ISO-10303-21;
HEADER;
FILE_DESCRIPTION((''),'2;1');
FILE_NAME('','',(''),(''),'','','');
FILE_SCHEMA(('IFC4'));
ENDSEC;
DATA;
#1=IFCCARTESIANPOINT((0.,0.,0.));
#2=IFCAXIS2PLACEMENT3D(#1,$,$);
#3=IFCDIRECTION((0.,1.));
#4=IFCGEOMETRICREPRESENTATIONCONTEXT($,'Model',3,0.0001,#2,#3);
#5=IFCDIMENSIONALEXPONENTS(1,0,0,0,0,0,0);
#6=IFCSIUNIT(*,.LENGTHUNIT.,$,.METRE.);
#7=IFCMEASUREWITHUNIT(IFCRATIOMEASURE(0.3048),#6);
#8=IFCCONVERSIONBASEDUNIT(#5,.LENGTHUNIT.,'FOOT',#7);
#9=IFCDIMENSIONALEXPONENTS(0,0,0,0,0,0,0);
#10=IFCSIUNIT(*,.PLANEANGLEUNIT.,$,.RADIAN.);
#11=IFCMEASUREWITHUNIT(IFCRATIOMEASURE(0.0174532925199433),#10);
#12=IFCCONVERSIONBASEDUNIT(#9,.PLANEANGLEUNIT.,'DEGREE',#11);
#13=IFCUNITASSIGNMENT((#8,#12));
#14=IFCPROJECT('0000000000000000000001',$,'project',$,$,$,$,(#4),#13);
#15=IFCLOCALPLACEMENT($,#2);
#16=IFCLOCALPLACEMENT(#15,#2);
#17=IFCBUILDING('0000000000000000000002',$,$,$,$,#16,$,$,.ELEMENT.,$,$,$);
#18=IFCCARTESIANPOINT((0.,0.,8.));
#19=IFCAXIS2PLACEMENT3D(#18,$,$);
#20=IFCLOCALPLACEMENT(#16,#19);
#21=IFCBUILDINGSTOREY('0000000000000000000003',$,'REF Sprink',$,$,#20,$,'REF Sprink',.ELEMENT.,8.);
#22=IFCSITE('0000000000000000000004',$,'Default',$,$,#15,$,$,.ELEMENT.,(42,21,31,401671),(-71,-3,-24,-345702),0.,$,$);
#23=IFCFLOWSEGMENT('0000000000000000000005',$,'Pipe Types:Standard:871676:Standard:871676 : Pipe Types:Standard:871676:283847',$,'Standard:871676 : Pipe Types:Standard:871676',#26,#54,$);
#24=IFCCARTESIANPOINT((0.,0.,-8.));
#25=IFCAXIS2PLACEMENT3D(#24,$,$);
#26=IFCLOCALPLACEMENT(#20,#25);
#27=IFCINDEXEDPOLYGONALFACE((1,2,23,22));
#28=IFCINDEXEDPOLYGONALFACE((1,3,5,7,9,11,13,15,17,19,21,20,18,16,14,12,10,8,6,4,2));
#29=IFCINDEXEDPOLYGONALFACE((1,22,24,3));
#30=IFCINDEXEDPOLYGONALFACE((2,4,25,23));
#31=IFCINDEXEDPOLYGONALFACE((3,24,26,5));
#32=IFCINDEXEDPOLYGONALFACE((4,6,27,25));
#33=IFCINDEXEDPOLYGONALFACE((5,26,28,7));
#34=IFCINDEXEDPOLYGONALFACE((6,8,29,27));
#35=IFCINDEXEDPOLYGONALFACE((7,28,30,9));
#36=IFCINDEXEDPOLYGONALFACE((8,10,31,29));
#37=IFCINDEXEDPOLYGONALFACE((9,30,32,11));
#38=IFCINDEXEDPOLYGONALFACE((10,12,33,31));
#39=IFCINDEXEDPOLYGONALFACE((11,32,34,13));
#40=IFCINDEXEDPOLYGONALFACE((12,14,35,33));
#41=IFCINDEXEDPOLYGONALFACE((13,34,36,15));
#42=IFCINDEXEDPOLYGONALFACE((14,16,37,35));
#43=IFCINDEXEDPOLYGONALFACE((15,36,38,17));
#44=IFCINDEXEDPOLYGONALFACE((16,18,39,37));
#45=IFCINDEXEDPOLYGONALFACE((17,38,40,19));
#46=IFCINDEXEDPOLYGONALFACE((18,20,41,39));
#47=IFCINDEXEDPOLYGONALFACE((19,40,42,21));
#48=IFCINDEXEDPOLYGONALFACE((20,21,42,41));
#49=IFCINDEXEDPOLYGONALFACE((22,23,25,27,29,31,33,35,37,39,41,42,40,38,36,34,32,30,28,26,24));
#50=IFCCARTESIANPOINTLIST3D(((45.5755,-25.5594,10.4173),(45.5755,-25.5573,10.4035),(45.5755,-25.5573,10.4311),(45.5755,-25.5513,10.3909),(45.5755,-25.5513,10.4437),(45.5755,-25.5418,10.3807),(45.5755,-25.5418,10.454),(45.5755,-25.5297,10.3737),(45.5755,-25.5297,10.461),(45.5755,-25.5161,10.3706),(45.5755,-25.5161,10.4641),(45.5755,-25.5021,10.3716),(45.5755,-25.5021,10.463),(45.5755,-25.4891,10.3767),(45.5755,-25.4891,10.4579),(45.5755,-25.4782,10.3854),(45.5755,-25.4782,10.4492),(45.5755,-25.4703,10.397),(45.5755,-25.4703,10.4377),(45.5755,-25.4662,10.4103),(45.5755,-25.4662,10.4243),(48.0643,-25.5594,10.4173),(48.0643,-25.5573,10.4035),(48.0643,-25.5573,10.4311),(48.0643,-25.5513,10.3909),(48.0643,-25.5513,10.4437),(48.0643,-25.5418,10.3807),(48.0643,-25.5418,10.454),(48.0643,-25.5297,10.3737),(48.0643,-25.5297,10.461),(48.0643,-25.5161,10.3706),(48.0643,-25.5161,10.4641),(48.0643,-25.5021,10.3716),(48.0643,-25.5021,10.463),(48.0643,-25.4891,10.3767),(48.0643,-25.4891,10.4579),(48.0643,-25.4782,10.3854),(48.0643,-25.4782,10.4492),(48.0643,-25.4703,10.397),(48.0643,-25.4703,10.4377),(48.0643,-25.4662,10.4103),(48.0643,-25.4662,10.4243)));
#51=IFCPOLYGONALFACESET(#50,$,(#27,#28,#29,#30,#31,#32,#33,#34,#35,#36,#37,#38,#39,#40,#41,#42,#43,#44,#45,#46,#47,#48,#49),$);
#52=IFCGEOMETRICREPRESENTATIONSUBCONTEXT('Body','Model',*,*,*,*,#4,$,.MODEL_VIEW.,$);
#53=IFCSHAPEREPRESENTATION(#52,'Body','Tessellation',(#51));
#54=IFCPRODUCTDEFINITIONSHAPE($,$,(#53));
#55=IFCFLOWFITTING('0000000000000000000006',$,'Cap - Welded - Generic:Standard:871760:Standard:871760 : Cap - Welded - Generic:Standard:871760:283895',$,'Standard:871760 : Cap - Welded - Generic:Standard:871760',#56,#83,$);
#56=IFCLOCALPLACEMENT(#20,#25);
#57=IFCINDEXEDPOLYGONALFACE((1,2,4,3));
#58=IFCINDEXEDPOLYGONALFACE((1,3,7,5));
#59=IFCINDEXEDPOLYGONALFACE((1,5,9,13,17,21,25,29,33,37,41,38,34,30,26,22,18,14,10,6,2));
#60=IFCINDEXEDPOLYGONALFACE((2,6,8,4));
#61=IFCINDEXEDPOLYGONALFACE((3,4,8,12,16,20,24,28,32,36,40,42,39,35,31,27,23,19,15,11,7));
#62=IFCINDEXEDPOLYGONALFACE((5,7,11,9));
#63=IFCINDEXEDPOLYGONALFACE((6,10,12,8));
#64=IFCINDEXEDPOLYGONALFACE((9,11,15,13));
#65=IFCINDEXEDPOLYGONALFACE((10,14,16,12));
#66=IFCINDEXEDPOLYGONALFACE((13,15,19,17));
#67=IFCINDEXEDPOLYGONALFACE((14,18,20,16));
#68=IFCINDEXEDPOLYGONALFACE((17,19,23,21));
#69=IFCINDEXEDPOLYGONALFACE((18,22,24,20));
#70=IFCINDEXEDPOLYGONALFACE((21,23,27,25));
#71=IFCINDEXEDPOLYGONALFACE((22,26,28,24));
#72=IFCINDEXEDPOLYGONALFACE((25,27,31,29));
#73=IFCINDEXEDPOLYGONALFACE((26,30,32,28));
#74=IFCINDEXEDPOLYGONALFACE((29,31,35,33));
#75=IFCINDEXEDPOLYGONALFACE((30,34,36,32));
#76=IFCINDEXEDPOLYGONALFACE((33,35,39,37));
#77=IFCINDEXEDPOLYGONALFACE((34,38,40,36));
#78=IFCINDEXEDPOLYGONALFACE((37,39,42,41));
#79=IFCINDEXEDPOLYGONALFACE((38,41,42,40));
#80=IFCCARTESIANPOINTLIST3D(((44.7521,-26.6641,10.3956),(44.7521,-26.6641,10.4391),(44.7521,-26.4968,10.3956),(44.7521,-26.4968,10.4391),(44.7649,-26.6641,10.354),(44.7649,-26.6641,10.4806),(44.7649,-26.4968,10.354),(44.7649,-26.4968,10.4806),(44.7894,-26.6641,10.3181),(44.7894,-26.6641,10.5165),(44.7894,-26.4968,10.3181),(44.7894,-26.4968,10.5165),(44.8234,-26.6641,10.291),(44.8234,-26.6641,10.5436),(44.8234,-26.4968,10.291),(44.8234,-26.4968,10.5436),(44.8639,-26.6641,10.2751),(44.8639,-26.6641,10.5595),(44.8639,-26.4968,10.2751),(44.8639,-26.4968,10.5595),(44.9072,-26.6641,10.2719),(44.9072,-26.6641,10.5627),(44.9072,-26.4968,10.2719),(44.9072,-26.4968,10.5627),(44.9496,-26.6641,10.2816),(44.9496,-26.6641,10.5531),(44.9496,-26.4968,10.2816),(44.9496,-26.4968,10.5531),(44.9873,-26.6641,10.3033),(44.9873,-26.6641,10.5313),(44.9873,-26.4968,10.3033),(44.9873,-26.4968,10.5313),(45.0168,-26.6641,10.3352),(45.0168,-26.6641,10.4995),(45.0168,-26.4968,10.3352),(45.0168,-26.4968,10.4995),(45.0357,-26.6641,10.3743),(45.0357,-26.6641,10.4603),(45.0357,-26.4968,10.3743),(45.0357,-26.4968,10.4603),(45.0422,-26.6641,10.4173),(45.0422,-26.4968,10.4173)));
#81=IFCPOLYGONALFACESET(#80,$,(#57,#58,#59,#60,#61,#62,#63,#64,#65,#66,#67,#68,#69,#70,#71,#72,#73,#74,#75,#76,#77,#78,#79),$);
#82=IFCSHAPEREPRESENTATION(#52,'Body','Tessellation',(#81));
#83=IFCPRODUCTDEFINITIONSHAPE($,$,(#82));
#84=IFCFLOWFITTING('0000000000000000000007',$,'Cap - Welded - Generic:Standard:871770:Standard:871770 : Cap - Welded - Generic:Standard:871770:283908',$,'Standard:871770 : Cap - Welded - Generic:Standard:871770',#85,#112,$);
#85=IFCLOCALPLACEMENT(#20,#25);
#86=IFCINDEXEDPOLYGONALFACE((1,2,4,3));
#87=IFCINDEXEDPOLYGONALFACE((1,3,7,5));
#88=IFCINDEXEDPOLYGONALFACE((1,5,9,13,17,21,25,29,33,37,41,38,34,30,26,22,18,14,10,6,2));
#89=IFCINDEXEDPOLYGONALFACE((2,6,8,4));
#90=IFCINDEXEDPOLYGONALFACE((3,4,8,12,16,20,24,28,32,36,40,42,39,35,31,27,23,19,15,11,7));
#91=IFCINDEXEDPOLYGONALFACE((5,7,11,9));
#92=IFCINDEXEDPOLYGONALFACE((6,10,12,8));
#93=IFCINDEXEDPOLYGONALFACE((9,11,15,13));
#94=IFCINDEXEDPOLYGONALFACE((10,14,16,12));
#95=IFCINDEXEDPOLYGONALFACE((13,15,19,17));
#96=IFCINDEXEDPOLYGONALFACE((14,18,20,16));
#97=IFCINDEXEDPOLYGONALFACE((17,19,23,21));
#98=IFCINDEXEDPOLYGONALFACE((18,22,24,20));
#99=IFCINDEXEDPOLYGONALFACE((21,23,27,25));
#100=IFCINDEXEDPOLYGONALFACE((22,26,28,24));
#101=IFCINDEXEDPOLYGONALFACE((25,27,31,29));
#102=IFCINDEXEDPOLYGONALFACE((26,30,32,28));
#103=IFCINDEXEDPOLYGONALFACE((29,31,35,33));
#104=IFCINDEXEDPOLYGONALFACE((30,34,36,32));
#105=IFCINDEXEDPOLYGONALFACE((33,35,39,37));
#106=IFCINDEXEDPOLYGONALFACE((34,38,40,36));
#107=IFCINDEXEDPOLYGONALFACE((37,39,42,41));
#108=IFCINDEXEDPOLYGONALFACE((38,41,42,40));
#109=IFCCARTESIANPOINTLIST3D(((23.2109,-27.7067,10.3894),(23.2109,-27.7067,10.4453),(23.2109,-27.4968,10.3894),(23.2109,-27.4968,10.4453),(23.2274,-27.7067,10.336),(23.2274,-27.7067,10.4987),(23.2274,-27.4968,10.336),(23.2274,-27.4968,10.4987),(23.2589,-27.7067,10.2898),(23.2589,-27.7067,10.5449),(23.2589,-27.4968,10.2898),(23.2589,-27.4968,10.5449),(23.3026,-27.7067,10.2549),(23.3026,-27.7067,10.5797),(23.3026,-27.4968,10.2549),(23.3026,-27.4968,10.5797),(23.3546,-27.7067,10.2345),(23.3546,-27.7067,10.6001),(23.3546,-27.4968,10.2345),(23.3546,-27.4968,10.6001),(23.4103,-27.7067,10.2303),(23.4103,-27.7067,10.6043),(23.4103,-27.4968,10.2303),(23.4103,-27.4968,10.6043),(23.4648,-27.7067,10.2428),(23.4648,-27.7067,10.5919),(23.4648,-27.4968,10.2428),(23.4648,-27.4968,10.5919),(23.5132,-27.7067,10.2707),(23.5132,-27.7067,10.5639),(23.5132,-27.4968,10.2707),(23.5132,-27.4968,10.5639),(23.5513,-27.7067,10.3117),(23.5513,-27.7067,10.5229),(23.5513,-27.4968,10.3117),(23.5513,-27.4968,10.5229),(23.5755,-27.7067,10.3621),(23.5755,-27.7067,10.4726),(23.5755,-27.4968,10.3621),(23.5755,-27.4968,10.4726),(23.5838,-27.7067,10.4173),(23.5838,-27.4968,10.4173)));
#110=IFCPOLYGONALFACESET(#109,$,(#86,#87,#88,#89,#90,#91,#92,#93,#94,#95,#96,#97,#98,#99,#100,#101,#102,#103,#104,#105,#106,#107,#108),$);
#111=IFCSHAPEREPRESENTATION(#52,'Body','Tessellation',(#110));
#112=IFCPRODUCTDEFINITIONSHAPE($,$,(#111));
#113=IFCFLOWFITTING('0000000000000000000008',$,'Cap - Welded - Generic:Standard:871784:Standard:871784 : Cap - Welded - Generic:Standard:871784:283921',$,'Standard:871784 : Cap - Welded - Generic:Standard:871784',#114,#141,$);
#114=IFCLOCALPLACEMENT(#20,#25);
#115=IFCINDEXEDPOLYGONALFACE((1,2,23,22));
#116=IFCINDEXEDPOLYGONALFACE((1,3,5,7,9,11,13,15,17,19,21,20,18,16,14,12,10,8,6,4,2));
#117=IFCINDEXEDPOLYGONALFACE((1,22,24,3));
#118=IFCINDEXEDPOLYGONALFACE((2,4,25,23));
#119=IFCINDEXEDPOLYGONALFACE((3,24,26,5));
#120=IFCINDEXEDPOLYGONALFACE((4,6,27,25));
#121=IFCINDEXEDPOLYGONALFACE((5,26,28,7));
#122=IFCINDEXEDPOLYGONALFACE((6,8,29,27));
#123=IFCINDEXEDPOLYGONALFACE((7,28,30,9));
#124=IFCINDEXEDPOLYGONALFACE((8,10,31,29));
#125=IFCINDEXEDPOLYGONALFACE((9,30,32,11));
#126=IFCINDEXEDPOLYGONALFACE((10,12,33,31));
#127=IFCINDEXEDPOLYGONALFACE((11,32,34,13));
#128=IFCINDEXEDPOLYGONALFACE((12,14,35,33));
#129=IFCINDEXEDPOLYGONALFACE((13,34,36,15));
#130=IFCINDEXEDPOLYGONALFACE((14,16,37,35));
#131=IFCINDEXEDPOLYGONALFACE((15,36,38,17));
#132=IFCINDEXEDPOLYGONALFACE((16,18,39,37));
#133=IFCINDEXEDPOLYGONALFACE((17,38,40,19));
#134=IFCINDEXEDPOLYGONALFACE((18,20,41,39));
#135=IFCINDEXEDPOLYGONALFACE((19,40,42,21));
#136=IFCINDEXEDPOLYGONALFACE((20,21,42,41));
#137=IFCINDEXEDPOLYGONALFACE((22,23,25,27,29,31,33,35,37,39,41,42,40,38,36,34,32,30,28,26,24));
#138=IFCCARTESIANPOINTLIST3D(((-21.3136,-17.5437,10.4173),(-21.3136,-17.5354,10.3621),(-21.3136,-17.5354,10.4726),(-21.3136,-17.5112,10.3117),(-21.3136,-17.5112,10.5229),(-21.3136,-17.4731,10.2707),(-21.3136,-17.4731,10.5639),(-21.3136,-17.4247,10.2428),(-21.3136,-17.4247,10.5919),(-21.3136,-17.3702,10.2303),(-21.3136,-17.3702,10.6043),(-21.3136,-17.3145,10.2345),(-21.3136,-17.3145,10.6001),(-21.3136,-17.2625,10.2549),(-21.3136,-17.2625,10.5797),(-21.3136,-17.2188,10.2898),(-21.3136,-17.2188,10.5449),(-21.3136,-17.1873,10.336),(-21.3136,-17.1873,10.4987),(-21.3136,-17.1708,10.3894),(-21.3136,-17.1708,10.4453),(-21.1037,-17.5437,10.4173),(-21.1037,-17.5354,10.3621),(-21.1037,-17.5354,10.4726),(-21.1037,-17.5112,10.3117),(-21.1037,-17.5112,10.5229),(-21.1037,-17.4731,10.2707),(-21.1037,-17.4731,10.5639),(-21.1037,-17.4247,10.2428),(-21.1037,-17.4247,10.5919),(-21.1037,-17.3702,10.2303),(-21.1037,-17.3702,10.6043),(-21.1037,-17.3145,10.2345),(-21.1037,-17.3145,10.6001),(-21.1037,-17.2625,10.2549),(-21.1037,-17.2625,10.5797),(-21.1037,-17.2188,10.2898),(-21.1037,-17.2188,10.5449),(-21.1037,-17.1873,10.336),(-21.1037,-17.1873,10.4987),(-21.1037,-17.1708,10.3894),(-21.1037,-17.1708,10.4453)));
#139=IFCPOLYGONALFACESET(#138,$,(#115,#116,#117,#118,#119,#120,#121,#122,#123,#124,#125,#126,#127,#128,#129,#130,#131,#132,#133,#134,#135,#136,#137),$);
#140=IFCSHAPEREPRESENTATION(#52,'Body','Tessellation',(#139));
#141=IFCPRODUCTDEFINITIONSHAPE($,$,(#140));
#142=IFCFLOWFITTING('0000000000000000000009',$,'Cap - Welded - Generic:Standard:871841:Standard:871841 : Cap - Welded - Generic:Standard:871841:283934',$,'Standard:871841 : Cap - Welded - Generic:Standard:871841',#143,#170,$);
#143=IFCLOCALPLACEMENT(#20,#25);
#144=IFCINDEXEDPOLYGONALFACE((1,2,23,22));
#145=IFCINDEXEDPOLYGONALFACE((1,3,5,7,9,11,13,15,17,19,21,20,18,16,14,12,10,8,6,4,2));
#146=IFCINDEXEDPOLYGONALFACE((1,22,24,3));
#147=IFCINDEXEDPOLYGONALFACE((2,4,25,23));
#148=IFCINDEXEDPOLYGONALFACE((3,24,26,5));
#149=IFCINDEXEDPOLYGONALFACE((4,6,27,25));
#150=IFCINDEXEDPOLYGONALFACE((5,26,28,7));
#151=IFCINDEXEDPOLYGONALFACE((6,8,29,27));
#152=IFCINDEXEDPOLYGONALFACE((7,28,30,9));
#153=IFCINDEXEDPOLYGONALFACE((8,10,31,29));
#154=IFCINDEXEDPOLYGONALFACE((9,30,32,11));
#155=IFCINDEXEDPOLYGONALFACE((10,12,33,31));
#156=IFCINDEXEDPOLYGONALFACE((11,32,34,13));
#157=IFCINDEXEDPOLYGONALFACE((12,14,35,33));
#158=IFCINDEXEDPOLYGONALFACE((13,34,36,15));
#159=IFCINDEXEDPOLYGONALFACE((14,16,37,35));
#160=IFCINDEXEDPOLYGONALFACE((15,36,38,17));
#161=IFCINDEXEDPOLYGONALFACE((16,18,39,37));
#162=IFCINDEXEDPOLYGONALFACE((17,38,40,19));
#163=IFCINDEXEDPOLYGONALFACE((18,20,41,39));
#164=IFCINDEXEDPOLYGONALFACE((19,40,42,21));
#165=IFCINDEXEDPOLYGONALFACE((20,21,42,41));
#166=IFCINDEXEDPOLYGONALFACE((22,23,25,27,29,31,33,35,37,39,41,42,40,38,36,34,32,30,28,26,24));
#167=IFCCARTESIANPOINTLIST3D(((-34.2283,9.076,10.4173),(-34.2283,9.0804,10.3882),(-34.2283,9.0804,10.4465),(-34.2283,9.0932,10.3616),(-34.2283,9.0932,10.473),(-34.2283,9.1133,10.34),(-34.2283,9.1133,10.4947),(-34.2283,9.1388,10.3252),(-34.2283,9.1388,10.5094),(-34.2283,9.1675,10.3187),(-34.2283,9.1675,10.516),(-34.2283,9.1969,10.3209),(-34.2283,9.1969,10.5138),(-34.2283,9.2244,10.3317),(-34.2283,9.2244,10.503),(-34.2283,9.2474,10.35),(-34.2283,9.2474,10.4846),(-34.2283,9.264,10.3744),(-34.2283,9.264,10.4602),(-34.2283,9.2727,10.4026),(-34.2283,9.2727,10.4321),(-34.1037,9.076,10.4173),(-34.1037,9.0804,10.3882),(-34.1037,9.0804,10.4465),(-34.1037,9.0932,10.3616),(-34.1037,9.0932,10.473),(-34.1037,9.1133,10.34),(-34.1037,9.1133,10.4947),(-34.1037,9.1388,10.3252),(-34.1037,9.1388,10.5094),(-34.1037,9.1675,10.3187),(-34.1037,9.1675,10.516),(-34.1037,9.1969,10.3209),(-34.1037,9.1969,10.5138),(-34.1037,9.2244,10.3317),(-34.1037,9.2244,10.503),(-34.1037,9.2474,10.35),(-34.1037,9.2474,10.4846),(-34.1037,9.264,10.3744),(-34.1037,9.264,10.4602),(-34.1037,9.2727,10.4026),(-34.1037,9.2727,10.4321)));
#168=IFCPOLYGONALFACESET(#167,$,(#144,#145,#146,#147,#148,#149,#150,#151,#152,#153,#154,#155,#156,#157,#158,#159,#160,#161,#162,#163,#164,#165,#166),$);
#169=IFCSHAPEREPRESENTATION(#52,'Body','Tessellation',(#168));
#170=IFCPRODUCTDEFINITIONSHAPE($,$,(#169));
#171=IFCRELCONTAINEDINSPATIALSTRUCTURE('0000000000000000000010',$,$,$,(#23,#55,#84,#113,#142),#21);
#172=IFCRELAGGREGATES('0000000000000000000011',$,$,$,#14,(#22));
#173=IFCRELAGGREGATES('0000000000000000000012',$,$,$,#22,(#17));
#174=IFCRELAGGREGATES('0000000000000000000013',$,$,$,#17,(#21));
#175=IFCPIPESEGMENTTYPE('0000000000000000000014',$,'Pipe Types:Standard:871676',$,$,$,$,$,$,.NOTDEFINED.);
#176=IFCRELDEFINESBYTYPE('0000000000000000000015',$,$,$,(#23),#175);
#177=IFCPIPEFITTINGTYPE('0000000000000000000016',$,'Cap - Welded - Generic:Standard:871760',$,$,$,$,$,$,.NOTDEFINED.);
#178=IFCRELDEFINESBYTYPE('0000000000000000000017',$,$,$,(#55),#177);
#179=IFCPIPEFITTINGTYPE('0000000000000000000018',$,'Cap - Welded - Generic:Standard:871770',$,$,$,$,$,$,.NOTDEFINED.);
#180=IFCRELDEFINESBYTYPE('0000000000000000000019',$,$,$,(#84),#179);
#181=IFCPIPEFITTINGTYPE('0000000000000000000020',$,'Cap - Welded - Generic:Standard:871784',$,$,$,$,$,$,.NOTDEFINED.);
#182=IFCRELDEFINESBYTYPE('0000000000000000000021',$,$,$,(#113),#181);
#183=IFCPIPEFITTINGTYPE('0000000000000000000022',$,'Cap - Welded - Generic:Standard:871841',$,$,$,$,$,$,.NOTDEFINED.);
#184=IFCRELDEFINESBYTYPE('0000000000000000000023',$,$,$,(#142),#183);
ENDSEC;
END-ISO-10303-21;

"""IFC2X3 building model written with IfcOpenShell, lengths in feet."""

from ifc_helpers import new_model, entity, si_unit, converted_unit, direction, frame, frame_2d, origin, origin_2d_with_axis, place, context, subcontext, project, spatial, circle, extrude, source, transform, mapped, type_object, type_shapes, element, save


model = new_model("IFC2X3")

# Units and contexts
model_context = context("Model", 3, precision=0.0001, world=origin(), true_north=direction((0.0, 1.0)))
body_context = subcontext(model_context, "Body", "Model", "MODEL_VIEW")
ifc_project = project(units=[converted_unit("LENGTHUNIT", "FOOT", entity("IfcRatioMeasure", 0.3048), si_unit("LENGTHUNIT", "METRE"), dimensions=[1, 0, 0, 0, 0, 0, 0]), converted_unit("PLANEANGLEUNIT", "DEGREE", entity("IfcRatioMeasure", 0.0174532925199433), si_unit("PLANEANGLEUNIT", "RADIAN"), dimensions=[0, 0, 0, 0, 0, 0, 0])], contexts=[model_context])

# Site, building, storey
site_placement = place(None, origin())
site = spatial("IfcSite", under=ifc_project, at=site_placement, Name="Default", CompositionType="ELEMENT", RefLatitude=(42, 21, 31, 401671), RefLongitude=(-71, -3, -24, -345702), RefElevation=0.0)
building_placement = place(site_placement, origin())
building = spatial("IfcBuilding", under=site, at=building_placement, CompositionType="ELEMENT")
storey_placement = place(building_placement, frame((0.0, 0.0, 8.0)))
storey = spatial("IfcBuildingStorey", under=building, at=storey_placement, Name="REF Sprink", LongName="REF Sprink", CompositionType="ELEMENT", Elevation=8.0)

# Flow segment
pipe_segment_type_1 = type_object("IfcPipeSegmentType", Name="Pipe Types:Standard:871676", PredefinedType="NOTDEFINED")
shared_shape_1 = source(origin(), body_context, "Body", "SweptSolid", [
    extrude(circle(Radius=0.0469, at=origin_2d_with_axis()), frame((45.5755, -25.5125, 10.4173), z_axis=(1.0, 0.0, 0.0), x_axis=(0.0, -1.0, 0.0)), (0.0, 0.0, 1.0), 2.4888),
])
type_shapes(pipe_segment_type_1, [shared_shape_1])
flow_segment_1_placement = place(storey_placement, frame((0.0, 0.0, -8.0)))
element("IfcFlowSegment", 1, at=flow_segment_1_placement, inside=storey, type_object=pipe_segment_type_1, Name="Pipe Types:Standard:871676:Standard:871676 : Pipe Types:Standard:871676:283847", ObjectType="Standard:871676 : Pipe Types:Standard:871676", context=body_context, shape_type="MappedRepresentation", body=[
    mapped(shared_shape_1, transform((0.0, 0.0, 0.0), scale=1.0)),
])

# Flow fittings
pipe_fitting_type_1 = type_object("IfcPipeFittingType", Name="Cap - Welded - Generic:Standard:871760", PredefinedType="NOTDEFINED")
shared_shape_2 = source(origin(), body_context, "Body", "SweptSolid", [
    extrude(circle(Radius=0.1458, at=frame_2d((0.0, 0.0), x_axis=(1.0, 0.0))), frame((44.8963, -26.6641, 10.4173), z_axis=(0.0, 1.0, 0.0), x_axis=(1.0, 0.0, 0.0)), (0.0, 0.0, 1.0), 0.1673),
])
type_shapes(pipe_fitting_type_1, [shared_shape_2])
flow_fitting_1_placement = place(storey_placement, frame((0.0, 0.0, -8.0)))
element("IfcFlowFitting", 2, at=flow_fitting_1_placement, inside=storey, type_object=pipe_fitting_type_1, Name="Cap - Welded - Generic:Standard:871760:Standard:871760 : Cap - Welded - Generic:Standard:871760:283895", ObjectType="Standard:871760 : Cap - Welded - Generic:Standard:871760", context=body_context, shape_type="MappedRepresentation", body=[
    mapped(shared_shape_2, transform((0.0, 0.0, 0.0), scale=1.0)),
])
pipe_fitting_type_2 = type_object("IfcPipeFittingType", Name="Cap - Welded - Generic:Standard:871770", PredefinedType="NOTDEFINED")
shared_shape_3 = source(origin(), body_context, "Body", "SweptSolid", [
    extrude(circle(Radius=0.1875, at=frame_2d((0.0, 0.0), x_axis=(1.0, 0.0))), frame((23.3963, -27.7067, 10.4173), z_axis=(0.0, 1.0, 0.0), x_axis=(1.0, 0.0, 0.0)), (0.0, 0.0, 1.0), 0.21),
])
type_shapes(pipe_fitting_type_2, [shared_shape_3])
flow_fitting_2_placement = place(storey_placement, frame((0.0, 0.0, -8.0)))
element("IfcFlowFitting", 3, at=flow_fitting_2_placement, inside=storey, type_object=pipe_fitting_type_2, Name="Cap - Welded - Generic:Standard:871770:Standard:871770 : Cap - Welded - Generic:Standard:871770:283908", ObjectType="Standard:871770 : Cap - Welded - Generic:Standard:871770", context=body_context, shape_type="MappedRepresentation", body=[
    mapped(shared_shape_3, transform((0.0, 0.0, 0.0), scale=1.0)),
])
pipe_fitting_type_3 = type_object("IfcPipeFittingType", Name="Cap - Welded - Generic:Standard:871784", PredefinedType="NOTDEFINED")
shared_shape_4 = source(origin(), body_context, "Body", "SweptSolid", [
    extrude(circle(Radius=0.1875, at=frame_2d((0.0, 0.0), x_axis=(1.0, 0.0))), frame((-21.3136, -17.3562, 10.4173), z_axis=(1.0, 0.0, 0.0), x_axis=(0.0, -1.0, 0.0)), (0.0, 0.0, 1.0), 0.21),
])
type_shapes(pipe_fitting_type_3, [shared_shape_4])
flow_fitting_3_placement = place(storey_placement, frame((0.0, 0.0, -8.0)))
element("IfcFlowFitting", 4, at=flow_fitting_3_placement, inside=storey, type_object=pipe_fitting_type_3, Name="Cap - Welded - Generic:Standard:871784:Standard:871784 : Cap - Welded - Generic:Standard:871784:283921", ObjectType="Standard:871784 : Cap - Welded - Generic:Standard:871784", context=body_context, shape_type="MappedRepresentation", body=[
    mapped(shared_shape_4, transform((0.0, 0.0, 0.0), scale=1.0)),
])
pipe_fitting_type_4 = type_object("IfcPipeFittingType", Name="Cap - Welded - Generic:Standard:871841", PredefinedType="NOTDEFINED")
shared_shape_5 = source(origin(), body_context, "Body", "SweptSolid", [
    extrude(circle(Radius=0.0989, at=origin_2d_with_axis()), frame((-34.2283, 9.1749, 10.4173), z_axis=(1.0, 0.0, 0.0), x_axis=(0.0, -1.0, 0.0)), (0.0, 0.0, 1.0), 0.1247),
])
type_shapes(pipe_fitting_type_4, [shared_shape_5])
flow_fitting_4_placement = place(storey_placement, frame((0.0, 0.0, -8.0)))
element("IfcFlowFitting", 5, at=flow_fitting_4_placement, inside=storey, type_object=pipe_fitting_type_4, Name="Cap - Welded - Generic:Standard:871841:Standard:871841 : Cap - Welded - Generic:Standard:871841:283934", ObjectType="Standard:871841 : Cap - Welded - Generic:Standard:871841", context=body_context, shape_type="MappedRepresentation", body=[
    mapped(shared_shape_5, transform((0.0, 0.0, 0.0), scale=1.0)),
])

save(model, "model.ifc")
